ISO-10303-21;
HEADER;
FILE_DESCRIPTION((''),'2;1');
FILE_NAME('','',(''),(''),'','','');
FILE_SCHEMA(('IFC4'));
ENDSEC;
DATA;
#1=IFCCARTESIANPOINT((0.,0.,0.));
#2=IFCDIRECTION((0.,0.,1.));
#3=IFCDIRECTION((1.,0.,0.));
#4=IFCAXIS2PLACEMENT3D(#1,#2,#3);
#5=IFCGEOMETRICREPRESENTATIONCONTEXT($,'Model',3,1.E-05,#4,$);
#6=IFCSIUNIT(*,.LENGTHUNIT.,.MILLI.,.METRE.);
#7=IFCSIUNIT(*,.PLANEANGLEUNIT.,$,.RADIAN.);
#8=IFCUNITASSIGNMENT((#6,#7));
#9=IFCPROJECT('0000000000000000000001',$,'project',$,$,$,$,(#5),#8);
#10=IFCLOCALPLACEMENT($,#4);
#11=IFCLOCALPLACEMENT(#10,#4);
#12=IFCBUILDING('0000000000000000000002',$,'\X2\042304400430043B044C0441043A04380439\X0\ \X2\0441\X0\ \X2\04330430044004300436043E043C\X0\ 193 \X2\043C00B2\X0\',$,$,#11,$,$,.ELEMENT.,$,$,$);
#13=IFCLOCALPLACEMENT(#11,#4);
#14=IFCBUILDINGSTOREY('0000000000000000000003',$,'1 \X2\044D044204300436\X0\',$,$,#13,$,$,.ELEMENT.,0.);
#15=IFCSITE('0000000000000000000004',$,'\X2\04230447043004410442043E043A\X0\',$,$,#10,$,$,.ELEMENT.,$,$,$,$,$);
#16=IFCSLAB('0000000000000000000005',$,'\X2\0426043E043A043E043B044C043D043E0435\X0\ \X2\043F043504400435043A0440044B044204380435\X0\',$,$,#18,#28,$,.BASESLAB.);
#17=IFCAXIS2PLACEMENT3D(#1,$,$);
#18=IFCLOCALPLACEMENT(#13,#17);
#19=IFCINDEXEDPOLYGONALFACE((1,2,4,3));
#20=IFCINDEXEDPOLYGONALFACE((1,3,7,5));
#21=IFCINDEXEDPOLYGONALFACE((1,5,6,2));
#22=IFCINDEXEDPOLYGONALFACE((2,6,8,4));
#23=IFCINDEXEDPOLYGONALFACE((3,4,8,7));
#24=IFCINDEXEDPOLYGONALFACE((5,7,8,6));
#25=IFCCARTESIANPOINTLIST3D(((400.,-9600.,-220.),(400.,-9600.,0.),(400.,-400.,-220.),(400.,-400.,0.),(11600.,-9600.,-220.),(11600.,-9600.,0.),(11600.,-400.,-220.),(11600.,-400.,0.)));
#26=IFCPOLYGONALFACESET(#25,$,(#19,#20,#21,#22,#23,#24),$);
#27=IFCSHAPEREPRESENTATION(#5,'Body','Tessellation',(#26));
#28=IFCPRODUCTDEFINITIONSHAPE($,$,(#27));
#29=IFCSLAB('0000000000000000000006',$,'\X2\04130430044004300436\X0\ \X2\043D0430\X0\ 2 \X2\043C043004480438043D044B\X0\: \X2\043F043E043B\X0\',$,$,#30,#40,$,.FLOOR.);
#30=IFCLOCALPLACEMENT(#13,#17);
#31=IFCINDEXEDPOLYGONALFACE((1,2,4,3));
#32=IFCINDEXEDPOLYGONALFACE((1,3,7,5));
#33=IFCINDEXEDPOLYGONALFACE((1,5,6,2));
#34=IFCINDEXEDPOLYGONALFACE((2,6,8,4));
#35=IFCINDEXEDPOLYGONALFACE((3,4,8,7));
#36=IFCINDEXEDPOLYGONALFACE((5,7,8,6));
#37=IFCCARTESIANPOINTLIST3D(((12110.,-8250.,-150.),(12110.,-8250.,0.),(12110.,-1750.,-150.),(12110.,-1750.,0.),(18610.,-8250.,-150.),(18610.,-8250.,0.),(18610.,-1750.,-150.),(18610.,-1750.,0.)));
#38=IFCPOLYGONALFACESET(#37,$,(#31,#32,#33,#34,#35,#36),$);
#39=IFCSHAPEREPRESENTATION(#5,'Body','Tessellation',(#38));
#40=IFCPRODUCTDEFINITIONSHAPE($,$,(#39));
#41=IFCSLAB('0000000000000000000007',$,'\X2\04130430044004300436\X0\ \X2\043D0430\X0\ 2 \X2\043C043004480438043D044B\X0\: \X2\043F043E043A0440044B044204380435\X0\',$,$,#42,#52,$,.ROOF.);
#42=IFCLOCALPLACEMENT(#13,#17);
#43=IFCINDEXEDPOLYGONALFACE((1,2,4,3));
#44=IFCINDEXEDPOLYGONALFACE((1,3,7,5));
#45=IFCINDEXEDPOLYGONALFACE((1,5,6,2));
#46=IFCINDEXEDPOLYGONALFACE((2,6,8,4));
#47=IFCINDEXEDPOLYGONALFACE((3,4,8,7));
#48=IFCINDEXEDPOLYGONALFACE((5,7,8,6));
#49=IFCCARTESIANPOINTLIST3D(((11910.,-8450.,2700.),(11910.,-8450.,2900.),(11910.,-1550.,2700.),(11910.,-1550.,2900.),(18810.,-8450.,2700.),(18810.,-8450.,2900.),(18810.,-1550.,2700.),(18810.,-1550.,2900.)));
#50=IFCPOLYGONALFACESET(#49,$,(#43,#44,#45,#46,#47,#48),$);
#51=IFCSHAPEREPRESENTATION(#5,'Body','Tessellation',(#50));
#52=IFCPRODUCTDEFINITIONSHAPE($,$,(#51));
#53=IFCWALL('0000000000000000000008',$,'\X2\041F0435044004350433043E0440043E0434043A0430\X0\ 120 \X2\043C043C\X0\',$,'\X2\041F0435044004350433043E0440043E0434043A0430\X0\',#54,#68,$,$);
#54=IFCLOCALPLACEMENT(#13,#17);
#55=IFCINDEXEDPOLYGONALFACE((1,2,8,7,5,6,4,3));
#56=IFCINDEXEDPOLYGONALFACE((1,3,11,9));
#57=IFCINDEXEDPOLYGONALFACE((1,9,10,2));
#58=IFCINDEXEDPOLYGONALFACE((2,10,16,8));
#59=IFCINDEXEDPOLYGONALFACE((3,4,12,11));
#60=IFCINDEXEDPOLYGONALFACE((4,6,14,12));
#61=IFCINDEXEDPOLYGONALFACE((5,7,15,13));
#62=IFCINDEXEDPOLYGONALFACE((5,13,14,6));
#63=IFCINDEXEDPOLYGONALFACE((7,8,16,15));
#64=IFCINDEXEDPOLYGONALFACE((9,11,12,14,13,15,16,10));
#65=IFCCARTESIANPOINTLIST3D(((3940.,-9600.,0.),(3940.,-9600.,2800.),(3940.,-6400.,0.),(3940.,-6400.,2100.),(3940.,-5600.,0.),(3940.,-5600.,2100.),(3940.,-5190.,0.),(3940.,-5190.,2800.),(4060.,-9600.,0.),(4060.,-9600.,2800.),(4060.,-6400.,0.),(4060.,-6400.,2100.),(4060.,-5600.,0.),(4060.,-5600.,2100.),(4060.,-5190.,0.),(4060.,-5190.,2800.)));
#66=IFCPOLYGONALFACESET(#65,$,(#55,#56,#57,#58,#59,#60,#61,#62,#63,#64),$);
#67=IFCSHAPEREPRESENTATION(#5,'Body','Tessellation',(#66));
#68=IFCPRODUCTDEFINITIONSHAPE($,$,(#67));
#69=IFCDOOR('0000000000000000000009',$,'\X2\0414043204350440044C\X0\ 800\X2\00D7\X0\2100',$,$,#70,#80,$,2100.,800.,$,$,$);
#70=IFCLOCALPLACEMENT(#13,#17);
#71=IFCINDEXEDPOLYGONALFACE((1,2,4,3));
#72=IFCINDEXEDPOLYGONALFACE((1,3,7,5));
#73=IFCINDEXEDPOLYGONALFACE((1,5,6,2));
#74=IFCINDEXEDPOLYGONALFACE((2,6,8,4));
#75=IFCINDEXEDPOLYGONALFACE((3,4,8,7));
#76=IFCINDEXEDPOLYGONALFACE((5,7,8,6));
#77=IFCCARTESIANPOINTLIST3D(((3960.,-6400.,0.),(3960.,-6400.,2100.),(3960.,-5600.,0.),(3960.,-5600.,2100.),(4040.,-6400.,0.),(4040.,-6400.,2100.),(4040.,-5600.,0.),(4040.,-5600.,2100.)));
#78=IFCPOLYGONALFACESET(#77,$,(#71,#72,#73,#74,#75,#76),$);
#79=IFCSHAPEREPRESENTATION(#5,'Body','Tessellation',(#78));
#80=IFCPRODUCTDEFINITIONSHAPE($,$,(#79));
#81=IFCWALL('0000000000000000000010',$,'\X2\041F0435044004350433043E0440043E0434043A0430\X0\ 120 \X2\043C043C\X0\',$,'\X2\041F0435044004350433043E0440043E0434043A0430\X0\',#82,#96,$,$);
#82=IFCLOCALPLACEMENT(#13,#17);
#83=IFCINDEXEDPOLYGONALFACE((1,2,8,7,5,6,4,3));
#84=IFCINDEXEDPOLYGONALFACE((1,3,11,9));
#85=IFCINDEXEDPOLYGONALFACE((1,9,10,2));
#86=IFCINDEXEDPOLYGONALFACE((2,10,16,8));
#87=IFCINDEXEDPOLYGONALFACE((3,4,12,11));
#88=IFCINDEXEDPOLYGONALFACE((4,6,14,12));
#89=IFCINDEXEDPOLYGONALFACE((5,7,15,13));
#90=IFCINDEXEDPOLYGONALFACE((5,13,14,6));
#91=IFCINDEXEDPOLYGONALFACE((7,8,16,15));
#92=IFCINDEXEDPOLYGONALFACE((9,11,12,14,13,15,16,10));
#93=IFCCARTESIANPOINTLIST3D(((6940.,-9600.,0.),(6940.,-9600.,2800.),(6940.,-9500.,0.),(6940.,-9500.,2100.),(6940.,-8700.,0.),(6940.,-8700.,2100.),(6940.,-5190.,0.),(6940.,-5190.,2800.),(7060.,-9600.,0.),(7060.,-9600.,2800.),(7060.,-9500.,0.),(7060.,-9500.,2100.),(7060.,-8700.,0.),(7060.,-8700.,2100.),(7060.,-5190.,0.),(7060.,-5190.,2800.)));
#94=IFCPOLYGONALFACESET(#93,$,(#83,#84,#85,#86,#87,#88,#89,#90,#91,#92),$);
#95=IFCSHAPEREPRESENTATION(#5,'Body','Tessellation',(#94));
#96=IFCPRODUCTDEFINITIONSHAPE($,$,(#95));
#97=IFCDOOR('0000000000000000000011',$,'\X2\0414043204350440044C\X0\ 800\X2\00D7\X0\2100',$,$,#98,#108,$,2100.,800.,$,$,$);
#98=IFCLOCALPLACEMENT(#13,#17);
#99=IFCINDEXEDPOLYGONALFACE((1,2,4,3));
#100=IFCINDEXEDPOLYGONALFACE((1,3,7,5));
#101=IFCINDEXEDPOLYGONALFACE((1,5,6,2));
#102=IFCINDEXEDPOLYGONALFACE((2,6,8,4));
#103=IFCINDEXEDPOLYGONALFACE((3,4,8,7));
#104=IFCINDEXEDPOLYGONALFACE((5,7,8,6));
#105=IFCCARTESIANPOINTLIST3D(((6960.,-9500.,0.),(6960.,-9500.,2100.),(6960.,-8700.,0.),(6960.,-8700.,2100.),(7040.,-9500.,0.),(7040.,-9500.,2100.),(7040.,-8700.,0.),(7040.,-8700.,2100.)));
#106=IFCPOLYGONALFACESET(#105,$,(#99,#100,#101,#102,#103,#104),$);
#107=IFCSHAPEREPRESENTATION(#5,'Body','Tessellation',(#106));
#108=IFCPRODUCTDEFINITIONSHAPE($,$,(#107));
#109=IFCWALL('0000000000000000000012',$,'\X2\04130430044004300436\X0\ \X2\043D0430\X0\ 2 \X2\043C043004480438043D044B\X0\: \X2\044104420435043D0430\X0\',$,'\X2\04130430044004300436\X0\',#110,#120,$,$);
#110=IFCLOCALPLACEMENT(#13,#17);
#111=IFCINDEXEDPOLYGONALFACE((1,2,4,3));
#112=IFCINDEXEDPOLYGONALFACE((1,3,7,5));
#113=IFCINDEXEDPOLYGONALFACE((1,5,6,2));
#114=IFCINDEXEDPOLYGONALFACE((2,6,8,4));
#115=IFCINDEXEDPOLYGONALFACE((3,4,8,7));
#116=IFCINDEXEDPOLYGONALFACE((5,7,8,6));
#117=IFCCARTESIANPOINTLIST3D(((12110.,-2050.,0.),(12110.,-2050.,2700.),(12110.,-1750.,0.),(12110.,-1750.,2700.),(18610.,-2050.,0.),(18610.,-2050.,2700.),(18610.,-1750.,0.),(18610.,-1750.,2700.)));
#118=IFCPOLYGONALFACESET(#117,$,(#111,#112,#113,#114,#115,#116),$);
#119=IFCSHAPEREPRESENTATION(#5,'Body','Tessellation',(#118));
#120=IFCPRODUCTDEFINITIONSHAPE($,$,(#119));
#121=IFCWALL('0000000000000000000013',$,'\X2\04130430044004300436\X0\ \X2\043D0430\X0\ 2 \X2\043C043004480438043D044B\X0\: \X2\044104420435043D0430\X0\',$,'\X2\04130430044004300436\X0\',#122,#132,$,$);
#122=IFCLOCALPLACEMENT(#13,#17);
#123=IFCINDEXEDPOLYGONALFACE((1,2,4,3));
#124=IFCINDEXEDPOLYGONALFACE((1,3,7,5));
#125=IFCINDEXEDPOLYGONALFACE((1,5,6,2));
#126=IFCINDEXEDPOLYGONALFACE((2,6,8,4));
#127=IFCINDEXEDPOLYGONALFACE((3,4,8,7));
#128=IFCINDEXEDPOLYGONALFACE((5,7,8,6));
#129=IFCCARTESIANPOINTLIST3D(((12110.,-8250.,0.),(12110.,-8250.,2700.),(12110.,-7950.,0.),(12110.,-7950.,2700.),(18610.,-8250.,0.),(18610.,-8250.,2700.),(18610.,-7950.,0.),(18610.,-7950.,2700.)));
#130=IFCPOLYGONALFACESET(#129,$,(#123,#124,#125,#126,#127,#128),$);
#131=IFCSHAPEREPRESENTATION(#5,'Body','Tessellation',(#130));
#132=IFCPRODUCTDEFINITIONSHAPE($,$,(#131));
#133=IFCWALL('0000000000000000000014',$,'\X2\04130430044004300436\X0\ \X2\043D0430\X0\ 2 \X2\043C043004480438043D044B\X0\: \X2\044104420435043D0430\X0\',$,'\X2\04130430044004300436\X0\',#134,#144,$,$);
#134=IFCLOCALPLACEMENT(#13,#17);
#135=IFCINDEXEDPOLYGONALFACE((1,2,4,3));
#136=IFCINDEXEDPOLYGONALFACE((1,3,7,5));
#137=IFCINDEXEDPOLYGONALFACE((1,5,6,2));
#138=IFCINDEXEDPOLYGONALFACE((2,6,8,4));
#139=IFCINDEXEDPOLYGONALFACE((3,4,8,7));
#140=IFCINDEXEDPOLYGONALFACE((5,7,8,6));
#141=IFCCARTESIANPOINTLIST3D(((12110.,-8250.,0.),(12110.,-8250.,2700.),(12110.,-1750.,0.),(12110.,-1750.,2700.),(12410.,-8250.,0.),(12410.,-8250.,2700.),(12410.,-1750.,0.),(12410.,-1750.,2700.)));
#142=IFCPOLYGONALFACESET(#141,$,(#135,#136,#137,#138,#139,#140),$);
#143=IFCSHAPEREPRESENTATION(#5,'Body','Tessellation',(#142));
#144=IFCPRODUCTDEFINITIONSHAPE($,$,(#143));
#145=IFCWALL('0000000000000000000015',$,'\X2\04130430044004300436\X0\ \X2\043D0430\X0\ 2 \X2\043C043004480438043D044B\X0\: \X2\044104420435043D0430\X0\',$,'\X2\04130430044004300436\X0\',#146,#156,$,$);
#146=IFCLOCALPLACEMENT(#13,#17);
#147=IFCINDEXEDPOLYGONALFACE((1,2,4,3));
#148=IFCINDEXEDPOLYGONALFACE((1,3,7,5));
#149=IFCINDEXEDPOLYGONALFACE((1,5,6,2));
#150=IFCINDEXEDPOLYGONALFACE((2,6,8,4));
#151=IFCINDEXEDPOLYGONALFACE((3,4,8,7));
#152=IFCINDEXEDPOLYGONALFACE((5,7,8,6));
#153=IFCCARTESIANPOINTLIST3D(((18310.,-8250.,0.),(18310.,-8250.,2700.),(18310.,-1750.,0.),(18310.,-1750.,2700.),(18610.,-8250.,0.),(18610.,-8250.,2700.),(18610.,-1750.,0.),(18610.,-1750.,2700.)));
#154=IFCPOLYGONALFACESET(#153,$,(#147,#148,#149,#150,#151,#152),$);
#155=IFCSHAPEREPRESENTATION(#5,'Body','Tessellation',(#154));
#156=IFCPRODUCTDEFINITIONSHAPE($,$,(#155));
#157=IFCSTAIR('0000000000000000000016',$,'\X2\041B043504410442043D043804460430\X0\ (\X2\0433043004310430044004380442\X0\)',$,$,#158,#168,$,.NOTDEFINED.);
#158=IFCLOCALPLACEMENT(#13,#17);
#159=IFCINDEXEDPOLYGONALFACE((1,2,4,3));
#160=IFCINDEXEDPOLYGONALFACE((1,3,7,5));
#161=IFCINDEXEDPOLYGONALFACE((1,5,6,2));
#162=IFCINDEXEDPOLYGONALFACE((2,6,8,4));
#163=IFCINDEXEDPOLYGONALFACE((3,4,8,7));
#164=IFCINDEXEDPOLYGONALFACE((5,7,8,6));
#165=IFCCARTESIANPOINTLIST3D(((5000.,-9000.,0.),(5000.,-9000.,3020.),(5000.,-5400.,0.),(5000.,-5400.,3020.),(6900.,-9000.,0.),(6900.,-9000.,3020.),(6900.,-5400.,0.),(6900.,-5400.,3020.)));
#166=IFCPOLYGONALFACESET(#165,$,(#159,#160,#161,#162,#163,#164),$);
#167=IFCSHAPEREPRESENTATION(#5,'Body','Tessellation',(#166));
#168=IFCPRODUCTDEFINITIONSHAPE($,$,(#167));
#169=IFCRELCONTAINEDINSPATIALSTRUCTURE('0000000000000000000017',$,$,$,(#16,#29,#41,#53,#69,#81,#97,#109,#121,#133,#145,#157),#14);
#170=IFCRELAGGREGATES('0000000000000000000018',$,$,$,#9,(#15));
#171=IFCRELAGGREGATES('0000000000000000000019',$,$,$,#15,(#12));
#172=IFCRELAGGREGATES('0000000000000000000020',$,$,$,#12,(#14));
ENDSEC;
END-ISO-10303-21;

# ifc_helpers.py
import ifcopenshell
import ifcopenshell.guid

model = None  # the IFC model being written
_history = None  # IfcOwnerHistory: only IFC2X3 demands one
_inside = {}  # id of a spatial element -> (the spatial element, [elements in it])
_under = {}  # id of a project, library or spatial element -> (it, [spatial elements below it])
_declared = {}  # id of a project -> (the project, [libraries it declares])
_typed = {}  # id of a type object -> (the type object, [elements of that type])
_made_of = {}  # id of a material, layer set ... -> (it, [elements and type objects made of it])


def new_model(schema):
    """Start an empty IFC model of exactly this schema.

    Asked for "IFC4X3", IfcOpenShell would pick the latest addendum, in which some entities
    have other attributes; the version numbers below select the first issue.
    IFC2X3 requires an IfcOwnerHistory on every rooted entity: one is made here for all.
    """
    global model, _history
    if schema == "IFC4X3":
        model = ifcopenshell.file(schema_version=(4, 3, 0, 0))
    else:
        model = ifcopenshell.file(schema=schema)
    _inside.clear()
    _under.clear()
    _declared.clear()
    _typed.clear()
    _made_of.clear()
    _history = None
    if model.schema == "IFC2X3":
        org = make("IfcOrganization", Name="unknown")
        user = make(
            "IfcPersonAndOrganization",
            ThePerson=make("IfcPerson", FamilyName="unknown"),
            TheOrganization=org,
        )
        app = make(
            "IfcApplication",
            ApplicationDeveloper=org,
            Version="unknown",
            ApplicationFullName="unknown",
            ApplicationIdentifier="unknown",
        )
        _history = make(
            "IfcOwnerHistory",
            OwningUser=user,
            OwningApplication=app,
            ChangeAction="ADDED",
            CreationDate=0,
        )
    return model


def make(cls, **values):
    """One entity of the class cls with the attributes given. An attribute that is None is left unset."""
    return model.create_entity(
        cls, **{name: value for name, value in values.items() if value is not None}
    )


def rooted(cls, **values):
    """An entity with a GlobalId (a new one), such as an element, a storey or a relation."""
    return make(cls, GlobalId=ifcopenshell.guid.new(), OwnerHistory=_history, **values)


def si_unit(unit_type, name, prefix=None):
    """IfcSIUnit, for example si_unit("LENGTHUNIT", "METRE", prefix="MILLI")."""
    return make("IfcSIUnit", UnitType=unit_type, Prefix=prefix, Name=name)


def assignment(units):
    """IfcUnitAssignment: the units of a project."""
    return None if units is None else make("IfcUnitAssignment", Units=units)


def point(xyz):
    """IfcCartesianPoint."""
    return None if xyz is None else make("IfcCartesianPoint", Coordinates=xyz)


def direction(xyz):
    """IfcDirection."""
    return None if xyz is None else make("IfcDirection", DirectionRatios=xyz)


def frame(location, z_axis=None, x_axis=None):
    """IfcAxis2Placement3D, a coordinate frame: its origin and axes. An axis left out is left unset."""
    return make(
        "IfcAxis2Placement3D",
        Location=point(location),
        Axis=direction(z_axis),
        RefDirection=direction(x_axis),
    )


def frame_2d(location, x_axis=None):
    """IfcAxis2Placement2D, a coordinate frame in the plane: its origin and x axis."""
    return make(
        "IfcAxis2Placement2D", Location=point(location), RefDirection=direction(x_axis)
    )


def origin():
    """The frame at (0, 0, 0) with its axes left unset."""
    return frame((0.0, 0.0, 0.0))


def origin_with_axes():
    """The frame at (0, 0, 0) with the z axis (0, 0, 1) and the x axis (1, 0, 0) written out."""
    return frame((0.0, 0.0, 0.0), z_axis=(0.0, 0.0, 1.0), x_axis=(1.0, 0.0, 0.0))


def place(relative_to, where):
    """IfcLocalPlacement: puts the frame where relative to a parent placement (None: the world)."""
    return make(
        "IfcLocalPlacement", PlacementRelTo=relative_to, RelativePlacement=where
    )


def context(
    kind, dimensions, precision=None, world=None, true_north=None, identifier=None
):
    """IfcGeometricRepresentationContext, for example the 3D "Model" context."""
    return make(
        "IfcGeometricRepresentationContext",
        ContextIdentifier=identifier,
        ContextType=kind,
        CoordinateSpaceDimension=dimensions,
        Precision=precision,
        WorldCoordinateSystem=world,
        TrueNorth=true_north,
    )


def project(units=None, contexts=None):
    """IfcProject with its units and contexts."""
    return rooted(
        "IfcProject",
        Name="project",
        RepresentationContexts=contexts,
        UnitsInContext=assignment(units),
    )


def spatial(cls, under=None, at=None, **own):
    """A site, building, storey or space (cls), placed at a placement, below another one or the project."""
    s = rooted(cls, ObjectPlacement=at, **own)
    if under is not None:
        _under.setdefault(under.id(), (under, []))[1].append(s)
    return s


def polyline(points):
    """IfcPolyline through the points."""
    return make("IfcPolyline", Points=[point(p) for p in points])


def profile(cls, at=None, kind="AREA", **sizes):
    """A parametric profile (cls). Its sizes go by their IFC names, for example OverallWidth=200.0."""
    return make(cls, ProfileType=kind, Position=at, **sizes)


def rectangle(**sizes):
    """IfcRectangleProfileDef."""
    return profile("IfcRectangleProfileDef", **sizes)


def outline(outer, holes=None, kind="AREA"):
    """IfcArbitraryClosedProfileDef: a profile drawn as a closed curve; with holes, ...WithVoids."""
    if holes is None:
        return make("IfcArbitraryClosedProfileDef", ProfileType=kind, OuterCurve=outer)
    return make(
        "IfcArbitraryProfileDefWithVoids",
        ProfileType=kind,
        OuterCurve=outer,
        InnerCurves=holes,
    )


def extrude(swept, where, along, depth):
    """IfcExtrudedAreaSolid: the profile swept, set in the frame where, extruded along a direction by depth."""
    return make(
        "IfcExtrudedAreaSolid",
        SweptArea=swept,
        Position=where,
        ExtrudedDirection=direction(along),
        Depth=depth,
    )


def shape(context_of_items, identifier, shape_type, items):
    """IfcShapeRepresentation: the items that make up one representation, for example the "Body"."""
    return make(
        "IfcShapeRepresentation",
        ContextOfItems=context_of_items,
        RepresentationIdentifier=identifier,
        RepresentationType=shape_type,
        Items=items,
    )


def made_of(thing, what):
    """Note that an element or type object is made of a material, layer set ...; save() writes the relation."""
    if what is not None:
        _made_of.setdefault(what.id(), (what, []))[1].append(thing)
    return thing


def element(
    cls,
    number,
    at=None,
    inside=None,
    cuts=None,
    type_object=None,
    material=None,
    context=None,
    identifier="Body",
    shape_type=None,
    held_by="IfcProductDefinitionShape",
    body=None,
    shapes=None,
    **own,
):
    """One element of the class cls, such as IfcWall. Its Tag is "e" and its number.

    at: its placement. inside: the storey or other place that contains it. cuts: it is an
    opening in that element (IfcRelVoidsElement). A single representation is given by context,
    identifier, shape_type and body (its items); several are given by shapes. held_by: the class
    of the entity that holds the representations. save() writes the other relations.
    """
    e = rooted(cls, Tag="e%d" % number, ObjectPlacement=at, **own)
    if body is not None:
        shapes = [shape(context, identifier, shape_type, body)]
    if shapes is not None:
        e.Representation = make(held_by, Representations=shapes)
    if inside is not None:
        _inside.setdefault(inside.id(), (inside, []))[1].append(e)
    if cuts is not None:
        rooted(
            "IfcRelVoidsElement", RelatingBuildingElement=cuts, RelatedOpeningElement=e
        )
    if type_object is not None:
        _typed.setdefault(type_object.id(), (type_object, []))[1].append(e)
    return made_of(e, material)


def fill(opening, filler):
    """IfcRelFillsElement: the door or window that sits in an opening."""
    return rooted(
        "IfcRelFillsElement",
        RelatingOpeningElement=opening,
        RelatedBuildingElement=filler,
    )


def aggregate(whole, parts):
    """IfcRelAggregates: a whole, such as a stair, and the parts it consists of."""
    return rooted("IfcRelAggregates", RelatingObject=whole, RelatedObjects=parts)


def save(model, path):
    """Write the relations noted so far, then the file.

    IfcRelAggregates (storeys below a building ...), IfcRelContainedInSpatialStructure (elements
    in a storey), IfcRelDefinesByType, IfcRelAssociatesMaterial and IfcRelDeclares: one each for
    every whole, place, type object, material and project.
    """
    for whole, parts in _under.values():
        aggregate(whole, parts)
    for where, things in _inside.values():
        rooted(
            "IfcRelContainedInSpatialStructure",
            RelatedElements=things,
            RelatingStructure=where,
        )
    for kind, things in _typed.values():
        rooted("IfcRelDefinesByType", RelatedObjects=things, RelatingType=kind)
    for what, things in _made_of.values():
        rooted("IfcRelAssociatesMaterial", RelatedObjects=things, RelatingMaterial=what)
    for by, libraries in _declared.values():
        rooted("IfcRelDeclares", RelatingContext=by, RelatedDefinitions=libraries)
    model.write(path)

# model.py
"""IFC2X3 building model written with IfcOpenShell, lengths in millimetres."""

from ifc_helpers import new_model, si_unit, frame, frame_2d, origin, origin_with_axes, place, context, project, spatial, polyline, rectangle, outline, extrude, element, fill, save


model = new_model("IFC2X3")

# Units and contexts
model_context = context("Model", 3, precision=1e-05, world=origin_with_axes())
ifc_project = project(units=[si_unit("LENGTHUNIT", "METRE", prefix="MILLI"), si_unit("PLANEANGLEUNIT", "RADIAN")], contexts=[model_context])

# Site, building, storey
site_placement = place(None, origin_with_axes())
site = spatial("IfcSite", under=ifc_project, at=site_placement, Name="Участок", CompositionType="ELEMENT")
building_placement = place(site_placement, origin_with_axes())
building = spatial("IfcBuilding", under=site, at=building_placement, Name="Уральский с гаражом 193 м²", CompositionType="ELEMENT")
storey_placement = place(building_placement, origin_with_axes())
storey = spatial("IfcBuildingStorey", under=building, at=storey_placement, Name="1 этаж", CompositionType="ELEMENT", Elevation=0.0)

# Slabs
slab_1_placement = place(storey_placement, origin_with_axes())
element("IfcSlab", 1, at=slab_1_placement, inside=storey, Name="Цокольное перекрытие", PredefinedType="BASESLAB", context=model_context, shape_type="SweptSolid", body=[
    extrude(outline(polyline([(400.0, -400.0), (11600.0, -400.0), (11600.0, -9600.0), (400.0, -9600.0), (400.0, -400.0)])), frame((0.0, 0.0, -220.0)), (0.0, 0.0, 1.0), 220.0),
])
slab_2_placement = place(storey_placement, origin_with_axes())
element("IfcSlab", 2, at=slab_2_placement, inside=storey, Name="Гараж на 2 машины: пол", PredefinedType="FLOOR", context=model_context, shape_type="SweptSolid", body=[
    extrude(rectangle(XDim=6500.0, YDim=6500.0, at=frame_2d((15360.0, -5000.0))), frame((0.0, 0.0, -150.0)), (0.0, 0.0, 1.0), 150.0),
])
slab_3_placement = place(storey_placement, origin_with_axes())
element("IfcSlab", 3, at=slab_3_placement, inside=storey, Name="Гараж на 2 машины: покрытие", PredefinedType="ROOF", context=model_context, shape_type="SweptSolid", body=[
    extrude(rectangle(XDim=6900.0, YDim=6900.0, at=frame_2d((15360.0, -5000.0))), frame((0.0, 0.0, 2700.0)), (0.0, 0.0, 1.0), 200.0),
])

# Walls, openings, doors
wall_1_placement = place(storey_placement, origin_with_axes())
wall_1 = element("IfcWall", 4, at=wall_1_placement, inside=storey, Name="Перегородка 120 мм", ObjectType="Перегородка", context=model_context, shape_type="SweptSolid", body=[
    extrude(rectangle(XDim=120.0, YDim=4410.0, at=frame_2d((4000.0, -7395.0))), origin(), (0.0, 0.0, 1.0), 2800.0),
])
opening_1_placement = place(storey_placement, origin_with_axes())
opening_1 = element("IfcOpeningElement", 5, at=opening_1_placement, cuts=wall_1, ObjectType="Opening", context=model_context, shape_type="SweptSolid", body=[
    extrude(rectangle(XDim=140.0, YDim=800.0, at=frame_2d((4000.0, -6000.0))), origin(), (0.0, 0.0, 1.0), 2100.0),
])
door_1_placement = place(storey_placement, origin_with_axes())
door_1 = element("IfcDoor", 6, at=door_1_placement, inside=storey, Name="Дверь 800×2100", OverallHeight=2100.0, OverallWidth=800.0, context=model_context, shape_type="SweptSolid", body=[
    extrude(rectangle(XDim=80.0, YDim=800.0, at=frame_2d((4000.0, -6000.0))), origin(), (0.0, 0.0, 1.0), 2100.0),
])
fill(opening_1, door_1)
wall_2_placement = place(storey_placement, origin_with_axes())
wall_2 = element("IfcWall", 7, at=wall_2_placement, inside=storey, Name="Перегородка 120 мм", ObjectType="Перегородка", context=model_context, shape_type="SweptSolid", body=[
    extrude(rectangle(XDim=120.0, YDim=4410.0, at=frame_2d((7000.0, -7395.0))), origin(), (0.0, 0.0, 1.0), 2800.0),
])
opening_2_placement = place(storey_placement, origin_with_axes())
opening_2 = element("IfcOpeningElement", 8, at=opening_2_placement, cuts=wall_2, ObjectType="Opening", context=model_context, shape_type="SweptSolid", body=[
    extrude(rectangle(XDim=140.0, YDim=800.0, at=frame_2d((7000.0, -9100.0))), origin(), (0.0, 0.0, 1.0), 2100.0),
])
door_2_placement = place(storey_placement, origin_with_axes())
door_2 = element("IfcDoor", 9, at=door_2_placement, inside=storey, Name="Дверь 800×2100", OverallHeight=2100.0, OverallWidth=800.0, context=model_context, shape_type="SweptSolid", body=[
    extrude(rectangle(XDim=80.0, YDim=800.0, at=frame_2d((7000.0, -9100.0))), origin(), (0.0, 0.0, 1.0), 2100.0),
])
fill(opening_2, door_2)

# Walls
wall_3_placement = place(storey_placement, origin_with_axes())
element("IfcWall", 10, at=wall_3_placement, inside=storey, Name="Гараж на 2 машины: стена", ObjectType="Гараж", context=model_context, shape_type="SweptSolid", body=[
    extrude(rectangle(XDim=6500.0, YDim=300.0, at=frame_2d((15360.0, -1900.0))), origin(), (0.0, 0.0, 1.0), 2700.0),
])
wall_4_placement = place(storey_placement, origin_with_axes())
element("IfcWall", 11, at=wall_4_placement, inside=storey, Name="Гараж на 2 машины: стена", ObjectType="Гараж", context=model_context, shape_type="SweptSolid", body=[
    extrude(rectangle(XDim=6500.0, YDim=300.0, at=frame_2d((15360.0, -8100.0))), origin(), (0.0, 0.0, 1.0), 2700.0),
])
wall_5_placement = place(storey_placement, origin_with_axes())
element("IfcWall", 12, at=wall_5_placement, inside=storey, Name="Гараж на 2 машины: стена", ObjectType="Гараж", context=model_context, shape_type="SweptSolid", body=[
    extrude(rectangle(XDim=300.0, YDim=6500.0, at=frame_2d((12260.0, -5000.0))), origin(), (0.0, 0.0, 1.0), 2700.0),
])
wall_6_placement = place(storey_placement, origin_with_axes())
element("IfcWall", 13, at=wall_6_placement, inside=storey, Name="Гараж на 2 машины: стена", ObjectType="Гараж", context=model_context, shape_type="SweptSolid", body=[
    extrude(rectangle(XDim=300.0, YDim=6500.0, at=frame_2d((18460.0, -5000.0))), origin(), (0.0, 0.0, 1.0), 2700.0),
])

# Stair
stair_placement = place(storey_placement, origin_with_axes())
element("IfcStair", 14, at=stair_placement, inside=storey, Name="Лестница (габарит)", ShapeType="NOTDEFINED", context=model_context, shape_type="SweptSolid", body=[
    extrude(rectangle(XDim=1900.0, YDim=3600.0, at=frame_2d((5950.0, -7200.0))), origin(), (0.0, 0.0, 1.0), 3020.0),
])

save(model, "model.ifc")
